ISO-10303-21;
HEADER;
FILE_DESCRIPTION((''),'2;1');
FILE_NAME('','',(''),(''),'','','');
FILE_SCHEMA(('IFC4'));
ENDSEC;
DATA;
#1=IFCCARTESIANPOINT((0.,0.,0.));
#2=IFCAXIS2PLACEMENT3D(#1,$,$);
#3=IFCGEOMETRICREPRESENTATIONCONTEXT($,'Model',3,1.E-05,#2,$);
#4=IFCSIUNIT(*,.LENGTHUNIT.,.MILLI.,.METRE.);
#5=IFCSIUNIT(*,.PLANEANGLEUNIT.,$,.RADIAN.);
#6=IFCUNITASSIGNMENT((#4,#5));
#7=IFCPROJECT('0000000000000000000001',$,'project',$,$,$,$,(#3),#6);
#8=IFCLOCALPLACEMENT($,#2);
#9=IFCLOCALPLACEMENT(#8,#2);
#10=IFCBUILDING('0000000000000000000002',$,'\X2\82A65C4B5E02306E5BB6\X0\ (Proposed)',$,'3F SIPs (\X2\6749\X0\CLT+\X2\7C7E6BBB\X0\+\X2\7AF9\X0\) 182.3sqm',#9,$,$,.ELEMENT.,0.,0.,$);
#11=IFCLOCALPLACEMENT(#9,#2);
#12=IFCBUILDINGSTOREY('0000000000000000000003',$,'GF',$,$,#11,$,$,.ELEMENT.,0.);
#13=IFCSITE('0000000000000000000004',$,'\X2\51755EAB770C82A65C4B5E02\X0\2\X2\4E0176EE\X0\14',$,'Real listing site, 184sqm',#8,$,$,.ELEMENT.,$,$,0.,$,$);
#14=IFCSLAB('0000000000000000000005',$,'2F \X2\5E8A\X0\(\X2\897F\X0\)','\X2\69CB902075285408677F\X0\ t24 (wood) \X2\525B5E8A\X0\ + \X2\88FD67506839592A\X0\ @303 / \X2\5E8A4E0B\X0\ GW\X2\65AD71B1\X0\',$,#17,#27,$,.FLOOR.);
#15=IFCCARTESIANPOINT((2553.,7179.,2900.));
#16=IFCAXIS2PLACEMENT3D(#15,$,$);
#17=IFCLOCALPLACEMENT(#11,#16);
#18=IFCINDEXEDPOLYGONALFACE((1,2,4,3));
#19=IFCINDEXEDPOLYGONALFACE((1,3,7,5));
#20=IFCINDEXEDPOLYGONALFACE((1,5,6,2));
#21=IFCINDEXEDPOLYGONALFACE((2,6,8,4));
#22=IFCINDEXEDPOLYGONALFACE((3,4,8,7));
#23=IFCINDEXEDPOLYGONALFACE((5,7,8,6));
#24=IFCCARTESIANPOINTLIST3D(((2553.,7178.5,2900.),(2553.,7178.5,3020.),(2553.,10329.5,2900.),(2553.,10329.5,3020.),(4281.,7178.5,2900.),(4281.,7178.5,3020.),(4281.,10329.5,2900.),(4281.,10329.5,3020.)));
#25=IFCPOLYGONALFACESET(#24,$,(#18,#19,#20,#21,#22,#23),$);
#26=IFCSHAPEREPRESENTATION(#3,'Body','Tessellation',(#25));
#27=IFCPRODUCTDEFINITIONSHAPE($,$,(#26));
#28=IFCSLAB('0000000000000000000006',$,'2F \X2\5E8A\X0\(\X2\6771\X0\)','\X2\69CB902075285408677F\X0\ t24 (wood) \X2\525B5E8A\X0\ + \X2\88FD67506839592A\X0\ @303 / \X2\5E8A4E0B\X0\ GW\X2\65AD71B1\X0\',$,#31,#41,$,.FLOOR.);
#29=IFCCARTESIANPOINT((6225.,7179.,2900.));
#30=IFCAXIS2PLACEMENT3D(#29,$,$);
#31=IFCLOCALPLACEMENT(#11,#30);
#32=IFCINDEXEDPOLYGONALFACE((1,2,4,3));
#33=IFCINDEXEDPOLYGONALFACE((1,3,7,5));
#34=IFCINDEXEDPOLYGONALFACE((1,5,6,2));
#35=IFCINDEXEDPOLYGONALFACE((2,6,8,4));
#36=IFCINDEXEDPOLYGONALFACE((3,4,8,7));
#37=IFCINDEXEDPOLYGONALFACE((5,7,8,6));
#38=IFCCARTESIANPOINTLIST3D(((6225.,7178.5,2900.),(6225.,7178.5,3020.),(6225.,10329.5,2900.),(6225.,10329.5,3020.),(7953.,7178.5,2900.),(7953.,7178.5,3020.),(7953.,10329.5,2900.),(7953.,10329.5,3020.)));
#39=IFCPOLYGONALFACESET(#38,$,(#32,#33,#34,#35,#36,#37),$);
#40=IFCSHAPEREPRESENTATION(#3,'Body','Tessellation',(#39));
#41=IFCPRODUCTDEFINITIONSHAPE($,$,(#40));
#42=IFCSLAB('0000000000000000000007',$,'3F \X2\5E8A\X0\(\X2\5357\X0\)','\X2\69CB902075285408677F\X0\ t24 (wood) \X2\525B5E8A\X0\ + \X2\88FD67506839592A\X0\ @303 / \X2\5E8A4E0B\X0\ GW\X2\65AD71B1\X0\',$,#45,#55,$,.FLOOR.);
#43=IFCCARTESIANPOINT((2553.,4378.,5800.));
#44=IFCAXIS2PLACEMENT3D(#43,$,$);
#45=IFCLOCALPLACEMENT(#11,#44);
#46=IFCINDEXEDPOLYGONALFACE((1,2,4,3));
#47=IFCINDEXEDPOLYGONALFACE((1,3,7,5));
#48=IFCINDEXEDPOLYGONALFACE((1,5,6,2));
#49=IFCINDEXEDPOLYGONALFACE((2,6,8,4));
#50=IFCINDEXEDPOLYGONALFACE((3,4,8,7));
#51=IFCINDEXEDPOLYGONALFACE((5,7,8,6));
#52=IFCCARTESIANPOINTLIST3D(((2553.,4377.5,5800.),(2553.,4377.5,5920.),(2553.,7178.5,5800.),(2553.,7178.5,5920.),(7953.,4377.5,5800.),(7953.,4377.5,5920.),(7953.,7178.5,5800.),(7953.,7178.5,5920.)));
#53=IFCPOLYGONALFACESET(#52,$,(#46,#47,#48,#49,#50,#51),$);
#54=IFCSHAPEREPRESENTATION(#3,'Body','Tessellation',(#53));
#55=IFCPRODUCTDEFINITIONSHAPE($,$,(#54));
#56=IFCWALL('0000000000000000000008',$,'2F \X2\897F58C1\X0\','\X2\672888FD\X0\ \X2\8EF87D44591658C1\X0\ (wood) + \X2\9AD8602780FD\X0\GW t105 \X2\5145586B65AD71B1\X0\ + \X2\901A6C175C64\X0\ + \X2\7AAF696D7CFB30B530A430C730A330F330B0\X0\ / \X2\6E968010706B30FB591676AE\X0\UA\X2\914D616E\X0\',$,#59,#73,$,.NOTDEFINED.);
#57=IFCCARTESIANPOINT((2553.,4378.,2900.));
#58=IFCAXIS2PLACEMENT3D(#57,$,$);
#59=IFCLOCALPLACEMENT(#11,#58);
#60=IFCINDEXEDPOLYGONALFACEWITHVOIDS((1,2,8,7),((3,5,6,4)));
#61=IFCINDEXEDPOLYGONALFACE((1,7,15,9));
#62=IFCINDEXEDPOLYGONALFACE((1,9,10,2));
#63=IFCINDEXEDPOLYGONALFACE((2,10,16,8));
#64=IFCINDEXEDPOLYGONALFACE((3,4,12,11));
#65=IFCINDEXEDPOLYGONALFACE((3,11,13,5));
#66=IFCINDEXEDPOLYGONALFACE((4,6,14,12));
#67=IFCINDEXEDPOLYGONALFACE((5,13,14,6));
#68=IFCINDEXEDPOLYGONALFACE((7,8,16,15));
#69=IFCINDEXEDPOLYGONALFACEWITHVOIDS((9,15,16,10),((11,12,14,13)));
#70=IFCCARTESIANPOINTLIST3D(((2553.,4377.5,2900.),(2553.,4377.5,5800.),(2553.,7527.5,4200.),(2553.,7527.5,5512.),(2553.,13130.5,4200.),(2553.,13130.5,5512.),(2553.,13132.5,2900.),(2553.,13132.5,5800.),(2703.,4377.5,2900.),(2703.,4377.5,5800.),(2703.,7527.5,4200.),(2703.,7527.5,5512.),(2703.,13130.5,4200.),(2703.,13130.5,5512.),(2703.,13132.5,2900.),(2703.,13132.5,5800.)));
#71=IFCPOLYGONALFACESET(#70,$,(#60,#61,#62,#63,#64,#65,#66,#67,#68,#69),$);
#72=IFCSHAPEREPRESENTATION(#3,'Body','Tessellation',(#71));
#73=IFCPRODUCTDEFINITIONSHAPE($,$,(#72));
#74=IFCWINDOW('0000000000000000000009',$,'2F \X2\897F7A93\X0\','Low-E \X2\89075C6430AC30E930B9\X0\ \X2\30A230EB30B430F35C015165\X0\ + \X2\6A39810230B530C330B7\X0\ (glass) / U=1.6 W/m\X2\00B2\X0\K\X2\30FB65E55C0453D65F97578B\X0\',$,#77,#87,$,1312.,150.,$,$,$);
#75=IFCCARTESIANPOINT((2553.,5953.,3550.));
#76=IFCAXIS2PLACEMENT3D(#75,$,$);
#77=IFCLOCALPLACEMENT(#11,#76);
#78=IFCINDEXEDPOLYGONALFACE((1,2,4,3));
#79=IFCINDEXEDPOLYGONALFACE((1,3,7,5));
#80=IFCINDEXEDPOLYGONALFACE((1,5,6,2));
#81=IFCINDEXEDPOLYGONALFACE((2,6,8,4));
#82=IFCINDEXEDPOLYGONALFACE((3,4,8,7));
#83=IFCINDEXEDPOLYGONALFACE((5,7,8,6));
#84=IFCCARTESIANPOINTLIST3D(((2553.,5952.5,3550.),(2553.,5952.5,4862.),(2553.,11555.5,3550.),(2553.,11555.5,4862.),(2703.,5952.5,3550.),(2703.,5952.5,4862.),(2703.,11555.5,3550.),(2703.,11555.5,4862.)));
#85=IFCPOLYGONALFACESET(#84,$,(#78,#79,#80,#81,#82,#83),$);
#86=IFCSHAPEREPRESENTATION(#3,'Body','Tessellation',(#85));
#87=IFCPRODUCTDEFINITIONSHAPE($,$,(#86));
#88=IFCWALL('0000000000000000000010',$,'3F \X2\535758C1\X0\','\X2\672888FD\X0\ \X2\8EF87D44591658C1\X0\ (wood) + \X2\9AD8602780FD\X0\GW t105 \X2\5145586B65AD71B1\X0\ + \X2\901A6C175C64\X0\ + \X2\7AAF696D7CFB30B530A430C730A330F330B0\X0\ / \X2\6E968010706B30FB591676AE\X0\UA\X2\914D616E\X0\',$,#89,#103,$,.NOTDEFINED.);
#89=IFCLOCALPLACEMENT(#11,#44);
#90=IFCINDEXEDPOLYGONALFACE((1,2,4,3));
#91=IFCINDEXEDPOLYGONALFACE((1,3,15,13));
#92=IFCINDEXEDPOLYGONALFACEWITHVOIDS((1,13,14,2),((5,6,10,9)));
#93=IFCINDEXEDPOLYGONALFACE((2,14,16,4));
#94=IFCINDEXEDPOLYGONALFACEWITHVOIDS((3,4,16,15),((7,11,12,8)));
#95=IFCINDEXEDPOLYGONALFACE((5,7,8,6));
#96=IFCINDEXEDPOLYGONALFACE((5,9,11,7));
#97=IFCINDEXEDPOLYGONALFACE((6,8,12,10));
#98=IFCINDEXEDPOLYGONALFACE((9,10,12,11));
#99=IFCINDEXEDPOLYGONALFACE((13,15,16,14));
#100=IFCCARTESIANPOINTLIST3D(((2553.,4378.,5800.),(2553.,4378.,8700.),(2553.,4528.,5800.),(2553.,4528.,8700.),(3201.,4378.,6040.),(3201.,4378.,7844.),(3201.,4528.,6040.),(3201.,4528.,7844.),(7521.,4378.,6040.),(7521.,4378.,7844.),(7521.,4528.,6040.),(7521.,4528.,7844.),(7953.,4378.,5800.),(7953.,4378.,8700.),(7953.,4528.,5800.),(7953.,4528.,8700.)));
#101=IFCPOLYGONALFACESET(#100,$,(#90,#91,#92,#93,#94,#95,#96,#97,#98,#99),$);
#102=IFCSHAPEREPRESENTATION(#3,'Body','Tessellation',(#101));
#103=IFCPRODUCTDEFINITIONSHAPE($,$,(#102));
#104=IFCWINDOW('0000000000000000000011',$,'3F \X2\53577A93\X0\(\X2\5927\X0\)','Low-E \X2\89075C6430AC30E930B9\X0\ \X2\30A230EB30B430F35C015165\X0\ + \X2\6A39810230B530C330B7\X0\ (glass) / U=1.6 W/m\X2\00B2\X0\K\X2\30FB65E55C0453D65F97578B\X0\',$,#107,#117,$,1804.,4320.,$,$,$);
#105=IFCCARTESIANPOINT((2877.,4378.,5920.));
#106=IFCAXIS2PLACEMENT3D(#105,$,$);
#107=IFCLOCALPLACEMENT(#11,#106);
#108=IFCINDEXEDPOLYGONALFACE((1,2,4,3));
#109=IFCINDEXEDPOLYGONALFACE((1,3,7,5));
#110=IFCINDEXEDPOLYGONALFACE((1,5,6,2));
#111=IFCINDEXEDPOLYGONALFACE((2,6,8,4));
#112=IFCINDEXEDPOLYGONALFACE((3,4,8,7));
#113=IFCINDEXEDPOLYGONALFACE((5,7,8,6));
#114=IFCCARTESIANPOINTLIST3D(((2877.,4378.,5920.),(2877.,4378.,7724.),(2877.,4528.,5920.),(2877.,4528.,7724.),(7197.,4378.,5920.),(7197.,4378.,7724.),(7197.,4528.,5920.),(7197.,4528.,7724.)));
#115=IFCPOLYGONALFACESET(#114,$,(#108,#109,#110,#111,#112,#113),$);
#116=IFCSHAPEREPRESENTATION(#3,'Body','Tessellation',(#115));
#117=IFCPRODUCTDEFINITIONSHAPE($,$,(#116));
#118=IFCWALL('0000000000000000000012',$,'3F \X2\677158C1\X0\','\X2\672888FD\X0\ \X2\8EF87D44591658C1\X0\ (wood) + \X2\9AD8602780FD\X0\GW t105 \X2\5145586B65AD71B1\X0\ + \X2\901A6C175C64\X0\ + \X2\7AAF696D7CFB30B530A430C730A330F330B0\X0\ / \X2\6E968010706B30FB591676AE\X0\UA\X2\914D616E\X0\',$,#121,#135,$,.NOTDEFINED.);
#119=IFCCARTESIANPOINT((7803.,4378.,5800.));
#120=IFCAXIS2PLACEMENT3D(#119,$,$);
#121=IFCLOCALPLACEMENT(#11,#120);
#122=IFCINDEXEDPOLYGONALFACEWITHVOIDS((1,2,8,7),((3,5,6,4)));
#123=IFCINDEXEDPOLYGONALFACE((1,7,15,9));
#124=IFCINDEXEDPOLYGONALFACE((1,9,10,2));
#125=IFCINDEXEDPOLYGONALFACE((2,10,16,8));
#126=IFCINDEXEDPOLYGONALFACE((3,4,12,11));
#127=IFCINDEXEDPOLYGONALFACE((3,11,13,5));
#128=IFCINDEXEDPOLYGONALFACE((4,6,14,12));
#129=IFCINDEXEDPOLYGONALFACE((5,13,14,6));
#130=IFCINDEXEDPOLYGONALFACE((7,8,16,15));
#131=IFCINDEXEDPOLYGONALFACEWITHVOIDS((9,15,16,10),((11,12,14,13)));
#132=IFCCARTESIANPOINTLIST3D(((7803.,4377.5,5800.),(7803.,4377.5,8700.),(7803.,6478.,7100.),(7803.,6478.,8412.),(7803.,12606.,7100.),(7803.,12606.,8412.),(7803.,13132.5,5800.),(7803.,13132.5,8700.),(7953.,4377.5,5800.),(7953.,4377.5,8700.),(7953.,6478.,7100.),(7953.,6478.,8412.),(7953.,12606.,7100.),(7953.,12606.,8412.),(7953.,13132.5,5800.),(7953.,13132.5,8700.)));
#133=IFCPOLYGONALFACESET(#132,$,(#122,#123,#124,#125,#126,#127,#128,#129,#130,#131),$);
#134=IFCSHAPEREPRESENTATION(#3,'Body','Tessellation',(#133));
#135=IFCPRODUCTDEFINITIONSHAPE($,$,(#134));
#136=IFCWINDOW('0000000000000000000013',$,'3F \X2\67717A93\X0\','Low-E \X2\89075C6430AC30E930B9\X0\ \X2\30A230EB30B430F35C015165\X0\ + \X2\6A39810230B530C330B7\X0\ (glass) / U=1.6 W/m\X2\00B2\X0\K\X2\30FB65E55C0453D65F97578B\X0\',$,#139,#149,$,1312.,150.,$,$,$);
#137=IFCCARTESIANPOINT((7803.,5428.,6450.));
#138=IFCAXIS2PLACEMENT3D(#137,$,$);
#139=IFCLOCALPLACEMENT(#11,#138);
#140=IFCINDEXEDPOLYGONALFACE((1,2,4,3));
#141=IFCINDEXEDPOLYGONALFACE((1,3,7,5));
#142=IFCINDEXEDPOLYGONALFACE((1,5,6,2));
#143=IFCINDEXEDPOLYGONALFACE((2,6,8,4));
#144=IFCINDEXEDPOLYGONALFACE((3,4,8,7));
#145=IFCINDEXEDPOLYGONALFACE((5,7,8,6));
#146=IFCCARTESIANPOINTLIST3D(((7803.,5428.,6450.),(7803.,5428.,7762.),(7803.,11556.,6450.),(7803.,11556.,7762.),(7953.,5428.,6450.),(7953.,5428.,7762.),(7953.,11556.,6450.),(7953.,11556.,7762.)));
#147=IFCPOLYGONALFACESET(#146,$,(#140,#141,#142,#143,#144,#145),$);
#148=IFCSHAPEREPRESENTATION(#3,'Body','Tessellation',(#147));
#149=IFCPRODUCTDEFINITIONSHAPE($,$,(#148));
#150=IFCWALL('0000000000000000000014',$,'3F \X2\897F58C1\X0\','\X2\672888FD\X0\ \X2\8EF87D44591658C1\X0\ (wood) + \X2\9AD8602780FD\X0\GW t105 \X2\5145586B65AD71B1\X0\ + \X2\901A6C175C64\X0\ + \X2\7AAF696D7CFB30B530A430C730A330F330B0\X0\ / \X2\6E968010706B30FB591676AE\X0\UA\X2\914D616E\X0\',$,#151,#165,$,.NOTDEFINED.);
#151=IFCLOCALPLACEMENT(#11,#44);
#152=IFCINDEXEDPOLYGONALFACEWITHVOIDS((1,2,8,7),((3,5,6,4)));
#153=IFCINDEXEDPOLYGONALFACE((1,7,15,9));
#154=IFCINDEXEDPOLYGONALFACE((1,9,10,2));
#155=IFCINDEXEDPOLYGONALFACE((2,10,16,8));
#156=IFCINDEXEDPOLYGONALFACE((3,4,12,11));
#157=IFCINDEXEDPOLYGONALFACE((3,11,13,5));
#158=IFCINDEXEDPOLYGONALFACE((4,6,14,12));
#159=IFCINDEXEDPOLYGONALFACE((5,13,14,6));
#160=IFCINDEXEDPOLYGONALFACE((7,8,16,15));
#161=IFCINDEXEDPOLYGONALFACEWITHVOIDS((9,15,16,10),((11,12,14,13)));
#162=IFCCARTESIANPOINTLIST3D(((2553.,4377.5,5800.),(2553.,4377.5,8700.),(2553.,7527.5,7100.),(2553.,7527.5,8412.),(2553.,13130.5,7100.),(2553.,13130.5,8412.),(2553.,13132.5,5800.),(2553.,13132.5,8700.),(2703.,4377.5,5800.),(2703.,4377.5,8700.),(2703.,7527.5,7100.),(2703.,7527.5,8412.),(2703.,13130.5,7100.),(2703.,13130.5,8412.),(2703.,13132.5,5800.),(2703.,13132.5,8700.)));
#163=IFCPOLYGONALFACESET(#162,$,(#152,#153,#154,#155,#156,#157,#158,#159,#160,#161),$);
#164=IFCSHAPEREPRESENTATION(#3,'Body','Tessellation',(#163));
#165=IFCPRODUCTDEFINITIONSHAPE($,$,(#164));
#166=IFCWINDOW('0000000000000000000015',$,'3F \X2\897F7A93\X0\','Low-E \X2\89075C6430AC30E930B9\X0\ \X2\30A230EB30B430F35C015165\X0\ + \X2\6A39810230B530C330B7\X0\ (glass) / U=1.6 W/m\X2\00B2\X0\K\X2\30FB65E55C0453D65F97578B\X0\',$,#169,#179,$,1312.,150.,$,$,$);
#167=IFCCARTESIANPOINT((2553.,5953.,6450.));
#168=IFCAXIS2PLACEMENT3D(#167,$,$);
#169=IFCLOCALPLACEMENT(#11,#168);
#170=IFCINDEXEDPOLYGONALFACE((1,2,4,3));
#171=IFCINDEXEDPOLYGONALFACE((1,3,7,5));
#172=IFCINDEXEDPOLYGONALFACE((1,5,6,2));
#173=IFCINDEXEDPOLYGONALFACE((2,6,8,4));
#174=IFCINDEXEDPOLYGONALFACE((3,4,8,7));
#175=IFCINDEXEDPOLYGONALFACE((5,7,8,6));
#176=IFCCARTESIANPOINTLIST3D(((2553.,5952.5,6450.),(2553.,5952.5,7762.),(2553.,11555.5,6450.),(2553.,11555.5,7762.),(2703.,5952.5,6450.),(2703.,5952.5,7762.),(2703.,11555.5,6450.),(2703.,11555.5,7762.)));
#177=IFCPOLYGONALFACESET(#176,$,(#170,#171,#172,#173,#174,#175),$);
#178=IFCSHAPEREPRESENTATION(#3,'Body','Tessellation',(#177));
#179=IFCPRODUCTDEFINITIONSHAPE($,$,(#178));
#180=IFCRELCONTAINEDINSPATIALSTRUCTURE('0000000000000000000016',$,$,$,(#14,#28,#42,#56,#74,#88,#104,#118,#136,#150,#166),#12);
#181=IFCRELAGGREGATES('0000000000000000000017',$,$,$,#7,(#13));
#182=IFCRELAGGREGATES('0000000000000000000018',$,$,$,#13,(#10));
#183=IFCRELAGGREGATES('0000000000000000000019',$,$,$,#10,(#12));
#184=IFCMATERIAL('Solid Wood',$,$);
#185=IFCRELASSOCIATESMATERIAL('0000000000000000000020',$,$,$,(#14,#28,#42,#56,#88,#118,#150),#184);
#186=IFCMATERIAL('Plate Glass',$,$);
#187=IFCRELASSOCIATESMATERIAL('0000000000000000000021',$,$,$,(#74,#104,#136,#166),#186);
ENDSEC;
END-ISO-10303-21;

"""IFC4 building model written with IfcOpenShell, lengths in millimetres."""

from ifc_helpers import new_model, si_unit, frame, frame_2d, origin, place, context, project, spatial, rectangle, extrude, material, element, fill, save


model = new_model("IFC4")

# Units and contexts
model_context = context("Model", 3, precision=1e-05, world=origin())
ifc_project = project(units=[si_unit("LENGTHUNIT", "METRE", prefix="MILLI"), si_unit("PLANEANGLEUNIT", "RADIAN")], contexts=[model_context])

# Site, building, storey
site_placement = place(None, origin())
site = spatial("IfcSite", under=ifc_project, at=site_placement, Name="兵庫県芦屋市2丁目14", ObjectType="Real listing site, 184sqm", CompositionType="ELEMENT", RefElevation=0.0)
building_placement = place(site_placement, origin())
building = spatial("IfcBuilding", under=site, at=building_placement, Name="芦屋市の家 (Proposed)", ObjectType="3F SIPs (杉CLT+籾殻+竹) 182.3sqm", CompositionType="ELEMENT", ElevationOfRefHeight=0.0, ElevationOfTerrain=0.0)
storey_placement = place(building_placement, origin())
storey = spatial("IfcBuildingStorey", under=building, at=storey_placement, Name="GF", CompositionType="ELEMENT", Elevation=0.0)

# Slabs
ifc_material_1 = material(Name="Solid Wood")
slab_1_placement = place(storey_placement, frame((2553.0, 7179.0, 2900.0)))
element("IfcSlab", 1, at=slab_1_placement, inside=storey, material=ifc_material_1, Name="2F 床(西)", Description="構造用合板 t24 (wood) 剛床 + 製材根太 @303 / 床下 GW断熱", PredefinedType="FLOOR", context=model_context, shape_type="SweptSolid", body=[
    extrude(rectangle(XDim=1728.0, YDim=3151.0, at=frame_2d((864.0, 1575.0))), frame((2553.0, 7179.0, 2900.0)), (0.0, 0.0, 1.0), 120.0),
])
slab_2_placement = place(storey_placement, frame((6225.0, 7179.0, 2900.0)))
element("IfcSlab", 2, at=slab_2_placement, inside=storey, material=ifc_material_1, Name="2F 床(東)", Description="構造用合板 t24 (wood) 剛床 + 製材根太 @303 / 床下 GW断熱", PredefinedType="FLOOR", context=model_context, shape_type="SweptSolid", body=[
    extrude(rectangle(XDim=1728.0, YDim=3151.0, at=frame_2d((864.0, 1575.0))), frame((6225.0, 7179.0, 2900.0)), (0.0, 0.0, 1.0), 120.0),
])
slab_3_placement = place(storey_placement, frame((2553.0, 4378.0, 5800.0)))
element("IfcSlab", 3, at=slab_3_placement, inside=storey, material=ifc_material_1, Name="3F 床(南)", Description="構造用合板 t24 (wood) 剛床 + 製材根太 @303 / 床下 GW断熱", PredefinedType="FLOOR", context=model_context, shape_type="SweptSolid", body=[
    extrude(rectangle(XDim=5400.0, YDim=2801.0, at=frame_2d((2700.0, 1400.0))), frame((2553.0, 4378.0, 5800.0)), (0.0, 0.0, 1.0), 120.0),
])

# Walls, openings, windows
wall_1_placement = place(storey_placement, frame((2553.0, 4378.0, 2900.0)))
wall_1 = element("IfcWall", 4, at=wall_1_placement, inside=storey, material=ifc_material_1, Name="2F 西壁", Description="木製 軸組外壁 (wood) + 高性能GW t105 充填断熱 + 通気層 + 窯業系サイディング / 準耐火・外皮UA配慮", PredefinedType="NOTDEFINED", context=model_context, shape_type="SweptSolid", body=[
    extrude(rectangle(XDim=150.0, YDim=8755.0, at=frame_2d((75.0, 4377.0))), frame((2553.0, 4378.0, 2900.0)), (0.0, 0.0, 1.0), 2900.0),
])
opening_1_placement = place(storey_placement, frame((2553.0, 5953.0, 3550.0)))
opening_1 = element("IfcOpeningElement", 5, at=opening_1_placement, cuts=wall_1, PredefinedType="NOTDEFINED", context=model_context, shape_type="SweptSolid", body=[
    extrude(rectangle(XDim=150.0, YDim=5603.0, at=frame_2d((75.0, 2801.0))), frame((2553.0, 5953.0, 3550.0)), (0.0, 0.0, 1.0), 1312.0),
])
ifc_material_2 = material(Name="Plate Glass")
window_1_placement = place(storey_placement, frame((2553.0, 5953.0, 3550.0)))
window_1 = element("IfcWindow", 6, at=window_1_placement, inside=storey, material=ifc_material_2, Name="2F 西窓", Description="Low-E 複層ガラス アルゴン封入 + 樹脂サッシ (glass) / U=1.6 W/m²K・日射取得型", OverallHeight=1312.0, OverallWidth=150.0, context=model_context, shape_type="SweptSolid", body=[
    extrude(rectangle(XDim=150.0, YDim=5603.0, at=frame_2d((75.0, 2801.0))), frame((2553.0, 5953.0, 3550.0)), (0.0, 0.0, 1.0), 1312.0),
])
fill(opening_1, window_1)
wall_2_placement = place(storey_placement, frame((2553.0, 4378.0, 5800.0)))
wall_2 = element("IfcWall", 7, at=wall_2_placement, inside=storey, material=ifc_material_1, Name="3F 南壁", Description="木製 軸組外壁 (wood) + 高性能GW t105 充填断熱 + 通気層 + 窯業系サイディング / 準耐火・外皮UA配慮", PredefinedType="NOTDEFINED", context=model_context, shape_type="SweptSolid", body=[
    extrude(rectangle(XDim=5400.0, YDim=150.0, at=frame_2d((2700.0, 75.0))), frame((2553.0, 4378.0, 5800.0)), (0.0, 0.0, 1.0), 2900.0),
])
opening_2_placement = place(storey_placement, frame((2877.0, 4378.0, 5920.0)))
opening_2 = element("IfcOpeningElement", 8, at=opening_2_placement, cuts=wall_2, PredefinedType="NOTDEFINED", context=model_context, shape_type="SweptSolid", body=[
    extrude(rectangle(XDim=4320.0, YDim=150.0, at=frame_2d((2160.0, 75.0))), frame((2877.0, 4378.0, 5920.0)), (0.0, 0.0, 1.0), 1804.0),
])
window_2_placement = place(storey_placement, frame((2877.0, 4378.0, 5920.0)))
window_2 = element("IfcWindow", 9, at=window_2_placement, inside=storey, material=ifc_material_2, Name="3F 南窓(大)", Description="Low-E 複層ガラス アルゴン封入 + 樹脂サッシ (glass) / U=1.6 W/m²K・日射取得型", OverallHeight=1804.0, OverallWidth=4320.0, context=model_context, shape_type="SweptSolid", body=[
    extrude(rectangle(XDim=4320.0, YDim=150.0, at=frame_2d((2160.0, 75.0))), frame((2877.0, 4378.0, 5920.0)), (0.0, 0.0, 1.0), 1804.0),
])
fill(opening_2, window_2)
wall_3_placement = place(storey_placement, frame((7803.0, 4378.0, 5800.0)))
wall_3 = element("IfcWall", 10, at=wall_3_placement, inside=storey, material=ifc_material_1, Name="3F 東壁", Description="木製 軸組外壁 (wood) + 高性能GW t105 充填断熱 + 通気層 + 窯業系サイディング / 準耐火・外皮UA配慮", PredefinedType="NOTDEFINED", context=model_context, shape_type="SweptSolid", body=[
    extrude(rectangle(XDim=150.0, YDim=8755.0, at=frame_2d((75.0, 4377.0))), frame((7803.0, 4378.0, 5800.0)), (0.0, 0.0, 1.0), 2900.0),
])
opening_3_placement = place(storey_placement, frame((7803.0, 5428.0, 6450.0)))
opening_3 = element("IfcOpeningElement", 11, at=opening_3_placement, cuts=wall_3, PredefinedType="NOTDEFINED", context=model_context, shape_type="SweptSolid", body=[
    extrude(rectangle(XDim=150.0, YDim=6128.0, at=frame_2d((75.0, 3064.0))), frame((7803.0, 5428.0, 6450.0)), (0.0, 0.0, 1.0), 1312.0),
])
window_3_placement = place(storey_placement, frame((7803.0, 5428.0, 6450.0)))
window_3 = element("IfcWindow", 12, at=window_3_placement, inside=storey, material=ifc_material_2, Name="3F 東窓", Description="Low-E 複層ガラス アルゴン封入 + 樹脂サッシ (glass) / U=1.6 W/m²K・日射取得型", OverallHeight=1312.0, OverallWidth=150.0, context=model_context, shape_type="SweptSolid", body=[
    extrude(rectangle(XDim=150.0, YDim=6128.0, at=frame_2d((75.0, 3064.0))), frame((7803.0, 5428.0, 6450.0)), (0.0, 0.0, 1.0), 1312.0),
])
fill(opening_3, window_3)
wall_4_placement = place(storey_placement, frame((2553.0, 4378.0, 5800.0)))
wall_4 = element("IfcWall", 13, at=wall_4_placement, inside=storey, material=ifc_material_1, Name="3F 西壁", Description="木製 軸組外壁 (wood) + 高性能GW t105 充填断熱 + 通気層 + 窯業系サイディング / 準耐火・外皮UA配慮", PredefinedType="NOTDEFINED", context=model_context, shape_type="SweptSolid", body=[
    extrude(rectangle(XDim=150.0, YDim=8755.0, at=frame_2d((75.0, 4377.0))), frame((2553.0, 4378.0, 5800.0)), (0.0, 0.0, 1.0), 2900.0),
])
opening_4_placement = place(storey_placement, frame((2553.0, 5953.0, 6450.0)))
opening_4 = element("IfcOpeningElement", 14, at=opening_4_placement, cuts=wall_4, PredefinedType="NOTDEFINED", context=model_context, shape_type="SweptSolid", body=[
    extrude(rectangle(XDim=150.0, YDim=5603.0, at=frame_2d((75.0, 2801.0))), frame((2553.0, 5953.0, 6450.0)), (0.0, 0.0, 1.0), 1312.0),
])
window_4_placement = place(storey_placement, frame((2553.0, 5953.0, 6450.0)))
window_4 = element("IfcWindow", 15, at=window_4_placement, inside=storey, material=ifc_material_2, Name="3F 西窓", Description="Low-E 複層ガラス アルゴン封入 + 樹脂サッシ (glass) / U=1.6 W/m²K・日射取得型", OverallHeight=1312.0, OverallWidth=150.0, context=model_context, shape_type="SweptSolid", body=[
    extrude(rectangle(XDim=150.0, YDim=5603.0, at=frame_2d((75.0, 2801.0))), frame((2553.0, 5953.0, 6450.0)), (0.0, 0.0, 1.0), 1312.0),
])
fill(opening_4, window_4)

save(model, "model.ifc")
